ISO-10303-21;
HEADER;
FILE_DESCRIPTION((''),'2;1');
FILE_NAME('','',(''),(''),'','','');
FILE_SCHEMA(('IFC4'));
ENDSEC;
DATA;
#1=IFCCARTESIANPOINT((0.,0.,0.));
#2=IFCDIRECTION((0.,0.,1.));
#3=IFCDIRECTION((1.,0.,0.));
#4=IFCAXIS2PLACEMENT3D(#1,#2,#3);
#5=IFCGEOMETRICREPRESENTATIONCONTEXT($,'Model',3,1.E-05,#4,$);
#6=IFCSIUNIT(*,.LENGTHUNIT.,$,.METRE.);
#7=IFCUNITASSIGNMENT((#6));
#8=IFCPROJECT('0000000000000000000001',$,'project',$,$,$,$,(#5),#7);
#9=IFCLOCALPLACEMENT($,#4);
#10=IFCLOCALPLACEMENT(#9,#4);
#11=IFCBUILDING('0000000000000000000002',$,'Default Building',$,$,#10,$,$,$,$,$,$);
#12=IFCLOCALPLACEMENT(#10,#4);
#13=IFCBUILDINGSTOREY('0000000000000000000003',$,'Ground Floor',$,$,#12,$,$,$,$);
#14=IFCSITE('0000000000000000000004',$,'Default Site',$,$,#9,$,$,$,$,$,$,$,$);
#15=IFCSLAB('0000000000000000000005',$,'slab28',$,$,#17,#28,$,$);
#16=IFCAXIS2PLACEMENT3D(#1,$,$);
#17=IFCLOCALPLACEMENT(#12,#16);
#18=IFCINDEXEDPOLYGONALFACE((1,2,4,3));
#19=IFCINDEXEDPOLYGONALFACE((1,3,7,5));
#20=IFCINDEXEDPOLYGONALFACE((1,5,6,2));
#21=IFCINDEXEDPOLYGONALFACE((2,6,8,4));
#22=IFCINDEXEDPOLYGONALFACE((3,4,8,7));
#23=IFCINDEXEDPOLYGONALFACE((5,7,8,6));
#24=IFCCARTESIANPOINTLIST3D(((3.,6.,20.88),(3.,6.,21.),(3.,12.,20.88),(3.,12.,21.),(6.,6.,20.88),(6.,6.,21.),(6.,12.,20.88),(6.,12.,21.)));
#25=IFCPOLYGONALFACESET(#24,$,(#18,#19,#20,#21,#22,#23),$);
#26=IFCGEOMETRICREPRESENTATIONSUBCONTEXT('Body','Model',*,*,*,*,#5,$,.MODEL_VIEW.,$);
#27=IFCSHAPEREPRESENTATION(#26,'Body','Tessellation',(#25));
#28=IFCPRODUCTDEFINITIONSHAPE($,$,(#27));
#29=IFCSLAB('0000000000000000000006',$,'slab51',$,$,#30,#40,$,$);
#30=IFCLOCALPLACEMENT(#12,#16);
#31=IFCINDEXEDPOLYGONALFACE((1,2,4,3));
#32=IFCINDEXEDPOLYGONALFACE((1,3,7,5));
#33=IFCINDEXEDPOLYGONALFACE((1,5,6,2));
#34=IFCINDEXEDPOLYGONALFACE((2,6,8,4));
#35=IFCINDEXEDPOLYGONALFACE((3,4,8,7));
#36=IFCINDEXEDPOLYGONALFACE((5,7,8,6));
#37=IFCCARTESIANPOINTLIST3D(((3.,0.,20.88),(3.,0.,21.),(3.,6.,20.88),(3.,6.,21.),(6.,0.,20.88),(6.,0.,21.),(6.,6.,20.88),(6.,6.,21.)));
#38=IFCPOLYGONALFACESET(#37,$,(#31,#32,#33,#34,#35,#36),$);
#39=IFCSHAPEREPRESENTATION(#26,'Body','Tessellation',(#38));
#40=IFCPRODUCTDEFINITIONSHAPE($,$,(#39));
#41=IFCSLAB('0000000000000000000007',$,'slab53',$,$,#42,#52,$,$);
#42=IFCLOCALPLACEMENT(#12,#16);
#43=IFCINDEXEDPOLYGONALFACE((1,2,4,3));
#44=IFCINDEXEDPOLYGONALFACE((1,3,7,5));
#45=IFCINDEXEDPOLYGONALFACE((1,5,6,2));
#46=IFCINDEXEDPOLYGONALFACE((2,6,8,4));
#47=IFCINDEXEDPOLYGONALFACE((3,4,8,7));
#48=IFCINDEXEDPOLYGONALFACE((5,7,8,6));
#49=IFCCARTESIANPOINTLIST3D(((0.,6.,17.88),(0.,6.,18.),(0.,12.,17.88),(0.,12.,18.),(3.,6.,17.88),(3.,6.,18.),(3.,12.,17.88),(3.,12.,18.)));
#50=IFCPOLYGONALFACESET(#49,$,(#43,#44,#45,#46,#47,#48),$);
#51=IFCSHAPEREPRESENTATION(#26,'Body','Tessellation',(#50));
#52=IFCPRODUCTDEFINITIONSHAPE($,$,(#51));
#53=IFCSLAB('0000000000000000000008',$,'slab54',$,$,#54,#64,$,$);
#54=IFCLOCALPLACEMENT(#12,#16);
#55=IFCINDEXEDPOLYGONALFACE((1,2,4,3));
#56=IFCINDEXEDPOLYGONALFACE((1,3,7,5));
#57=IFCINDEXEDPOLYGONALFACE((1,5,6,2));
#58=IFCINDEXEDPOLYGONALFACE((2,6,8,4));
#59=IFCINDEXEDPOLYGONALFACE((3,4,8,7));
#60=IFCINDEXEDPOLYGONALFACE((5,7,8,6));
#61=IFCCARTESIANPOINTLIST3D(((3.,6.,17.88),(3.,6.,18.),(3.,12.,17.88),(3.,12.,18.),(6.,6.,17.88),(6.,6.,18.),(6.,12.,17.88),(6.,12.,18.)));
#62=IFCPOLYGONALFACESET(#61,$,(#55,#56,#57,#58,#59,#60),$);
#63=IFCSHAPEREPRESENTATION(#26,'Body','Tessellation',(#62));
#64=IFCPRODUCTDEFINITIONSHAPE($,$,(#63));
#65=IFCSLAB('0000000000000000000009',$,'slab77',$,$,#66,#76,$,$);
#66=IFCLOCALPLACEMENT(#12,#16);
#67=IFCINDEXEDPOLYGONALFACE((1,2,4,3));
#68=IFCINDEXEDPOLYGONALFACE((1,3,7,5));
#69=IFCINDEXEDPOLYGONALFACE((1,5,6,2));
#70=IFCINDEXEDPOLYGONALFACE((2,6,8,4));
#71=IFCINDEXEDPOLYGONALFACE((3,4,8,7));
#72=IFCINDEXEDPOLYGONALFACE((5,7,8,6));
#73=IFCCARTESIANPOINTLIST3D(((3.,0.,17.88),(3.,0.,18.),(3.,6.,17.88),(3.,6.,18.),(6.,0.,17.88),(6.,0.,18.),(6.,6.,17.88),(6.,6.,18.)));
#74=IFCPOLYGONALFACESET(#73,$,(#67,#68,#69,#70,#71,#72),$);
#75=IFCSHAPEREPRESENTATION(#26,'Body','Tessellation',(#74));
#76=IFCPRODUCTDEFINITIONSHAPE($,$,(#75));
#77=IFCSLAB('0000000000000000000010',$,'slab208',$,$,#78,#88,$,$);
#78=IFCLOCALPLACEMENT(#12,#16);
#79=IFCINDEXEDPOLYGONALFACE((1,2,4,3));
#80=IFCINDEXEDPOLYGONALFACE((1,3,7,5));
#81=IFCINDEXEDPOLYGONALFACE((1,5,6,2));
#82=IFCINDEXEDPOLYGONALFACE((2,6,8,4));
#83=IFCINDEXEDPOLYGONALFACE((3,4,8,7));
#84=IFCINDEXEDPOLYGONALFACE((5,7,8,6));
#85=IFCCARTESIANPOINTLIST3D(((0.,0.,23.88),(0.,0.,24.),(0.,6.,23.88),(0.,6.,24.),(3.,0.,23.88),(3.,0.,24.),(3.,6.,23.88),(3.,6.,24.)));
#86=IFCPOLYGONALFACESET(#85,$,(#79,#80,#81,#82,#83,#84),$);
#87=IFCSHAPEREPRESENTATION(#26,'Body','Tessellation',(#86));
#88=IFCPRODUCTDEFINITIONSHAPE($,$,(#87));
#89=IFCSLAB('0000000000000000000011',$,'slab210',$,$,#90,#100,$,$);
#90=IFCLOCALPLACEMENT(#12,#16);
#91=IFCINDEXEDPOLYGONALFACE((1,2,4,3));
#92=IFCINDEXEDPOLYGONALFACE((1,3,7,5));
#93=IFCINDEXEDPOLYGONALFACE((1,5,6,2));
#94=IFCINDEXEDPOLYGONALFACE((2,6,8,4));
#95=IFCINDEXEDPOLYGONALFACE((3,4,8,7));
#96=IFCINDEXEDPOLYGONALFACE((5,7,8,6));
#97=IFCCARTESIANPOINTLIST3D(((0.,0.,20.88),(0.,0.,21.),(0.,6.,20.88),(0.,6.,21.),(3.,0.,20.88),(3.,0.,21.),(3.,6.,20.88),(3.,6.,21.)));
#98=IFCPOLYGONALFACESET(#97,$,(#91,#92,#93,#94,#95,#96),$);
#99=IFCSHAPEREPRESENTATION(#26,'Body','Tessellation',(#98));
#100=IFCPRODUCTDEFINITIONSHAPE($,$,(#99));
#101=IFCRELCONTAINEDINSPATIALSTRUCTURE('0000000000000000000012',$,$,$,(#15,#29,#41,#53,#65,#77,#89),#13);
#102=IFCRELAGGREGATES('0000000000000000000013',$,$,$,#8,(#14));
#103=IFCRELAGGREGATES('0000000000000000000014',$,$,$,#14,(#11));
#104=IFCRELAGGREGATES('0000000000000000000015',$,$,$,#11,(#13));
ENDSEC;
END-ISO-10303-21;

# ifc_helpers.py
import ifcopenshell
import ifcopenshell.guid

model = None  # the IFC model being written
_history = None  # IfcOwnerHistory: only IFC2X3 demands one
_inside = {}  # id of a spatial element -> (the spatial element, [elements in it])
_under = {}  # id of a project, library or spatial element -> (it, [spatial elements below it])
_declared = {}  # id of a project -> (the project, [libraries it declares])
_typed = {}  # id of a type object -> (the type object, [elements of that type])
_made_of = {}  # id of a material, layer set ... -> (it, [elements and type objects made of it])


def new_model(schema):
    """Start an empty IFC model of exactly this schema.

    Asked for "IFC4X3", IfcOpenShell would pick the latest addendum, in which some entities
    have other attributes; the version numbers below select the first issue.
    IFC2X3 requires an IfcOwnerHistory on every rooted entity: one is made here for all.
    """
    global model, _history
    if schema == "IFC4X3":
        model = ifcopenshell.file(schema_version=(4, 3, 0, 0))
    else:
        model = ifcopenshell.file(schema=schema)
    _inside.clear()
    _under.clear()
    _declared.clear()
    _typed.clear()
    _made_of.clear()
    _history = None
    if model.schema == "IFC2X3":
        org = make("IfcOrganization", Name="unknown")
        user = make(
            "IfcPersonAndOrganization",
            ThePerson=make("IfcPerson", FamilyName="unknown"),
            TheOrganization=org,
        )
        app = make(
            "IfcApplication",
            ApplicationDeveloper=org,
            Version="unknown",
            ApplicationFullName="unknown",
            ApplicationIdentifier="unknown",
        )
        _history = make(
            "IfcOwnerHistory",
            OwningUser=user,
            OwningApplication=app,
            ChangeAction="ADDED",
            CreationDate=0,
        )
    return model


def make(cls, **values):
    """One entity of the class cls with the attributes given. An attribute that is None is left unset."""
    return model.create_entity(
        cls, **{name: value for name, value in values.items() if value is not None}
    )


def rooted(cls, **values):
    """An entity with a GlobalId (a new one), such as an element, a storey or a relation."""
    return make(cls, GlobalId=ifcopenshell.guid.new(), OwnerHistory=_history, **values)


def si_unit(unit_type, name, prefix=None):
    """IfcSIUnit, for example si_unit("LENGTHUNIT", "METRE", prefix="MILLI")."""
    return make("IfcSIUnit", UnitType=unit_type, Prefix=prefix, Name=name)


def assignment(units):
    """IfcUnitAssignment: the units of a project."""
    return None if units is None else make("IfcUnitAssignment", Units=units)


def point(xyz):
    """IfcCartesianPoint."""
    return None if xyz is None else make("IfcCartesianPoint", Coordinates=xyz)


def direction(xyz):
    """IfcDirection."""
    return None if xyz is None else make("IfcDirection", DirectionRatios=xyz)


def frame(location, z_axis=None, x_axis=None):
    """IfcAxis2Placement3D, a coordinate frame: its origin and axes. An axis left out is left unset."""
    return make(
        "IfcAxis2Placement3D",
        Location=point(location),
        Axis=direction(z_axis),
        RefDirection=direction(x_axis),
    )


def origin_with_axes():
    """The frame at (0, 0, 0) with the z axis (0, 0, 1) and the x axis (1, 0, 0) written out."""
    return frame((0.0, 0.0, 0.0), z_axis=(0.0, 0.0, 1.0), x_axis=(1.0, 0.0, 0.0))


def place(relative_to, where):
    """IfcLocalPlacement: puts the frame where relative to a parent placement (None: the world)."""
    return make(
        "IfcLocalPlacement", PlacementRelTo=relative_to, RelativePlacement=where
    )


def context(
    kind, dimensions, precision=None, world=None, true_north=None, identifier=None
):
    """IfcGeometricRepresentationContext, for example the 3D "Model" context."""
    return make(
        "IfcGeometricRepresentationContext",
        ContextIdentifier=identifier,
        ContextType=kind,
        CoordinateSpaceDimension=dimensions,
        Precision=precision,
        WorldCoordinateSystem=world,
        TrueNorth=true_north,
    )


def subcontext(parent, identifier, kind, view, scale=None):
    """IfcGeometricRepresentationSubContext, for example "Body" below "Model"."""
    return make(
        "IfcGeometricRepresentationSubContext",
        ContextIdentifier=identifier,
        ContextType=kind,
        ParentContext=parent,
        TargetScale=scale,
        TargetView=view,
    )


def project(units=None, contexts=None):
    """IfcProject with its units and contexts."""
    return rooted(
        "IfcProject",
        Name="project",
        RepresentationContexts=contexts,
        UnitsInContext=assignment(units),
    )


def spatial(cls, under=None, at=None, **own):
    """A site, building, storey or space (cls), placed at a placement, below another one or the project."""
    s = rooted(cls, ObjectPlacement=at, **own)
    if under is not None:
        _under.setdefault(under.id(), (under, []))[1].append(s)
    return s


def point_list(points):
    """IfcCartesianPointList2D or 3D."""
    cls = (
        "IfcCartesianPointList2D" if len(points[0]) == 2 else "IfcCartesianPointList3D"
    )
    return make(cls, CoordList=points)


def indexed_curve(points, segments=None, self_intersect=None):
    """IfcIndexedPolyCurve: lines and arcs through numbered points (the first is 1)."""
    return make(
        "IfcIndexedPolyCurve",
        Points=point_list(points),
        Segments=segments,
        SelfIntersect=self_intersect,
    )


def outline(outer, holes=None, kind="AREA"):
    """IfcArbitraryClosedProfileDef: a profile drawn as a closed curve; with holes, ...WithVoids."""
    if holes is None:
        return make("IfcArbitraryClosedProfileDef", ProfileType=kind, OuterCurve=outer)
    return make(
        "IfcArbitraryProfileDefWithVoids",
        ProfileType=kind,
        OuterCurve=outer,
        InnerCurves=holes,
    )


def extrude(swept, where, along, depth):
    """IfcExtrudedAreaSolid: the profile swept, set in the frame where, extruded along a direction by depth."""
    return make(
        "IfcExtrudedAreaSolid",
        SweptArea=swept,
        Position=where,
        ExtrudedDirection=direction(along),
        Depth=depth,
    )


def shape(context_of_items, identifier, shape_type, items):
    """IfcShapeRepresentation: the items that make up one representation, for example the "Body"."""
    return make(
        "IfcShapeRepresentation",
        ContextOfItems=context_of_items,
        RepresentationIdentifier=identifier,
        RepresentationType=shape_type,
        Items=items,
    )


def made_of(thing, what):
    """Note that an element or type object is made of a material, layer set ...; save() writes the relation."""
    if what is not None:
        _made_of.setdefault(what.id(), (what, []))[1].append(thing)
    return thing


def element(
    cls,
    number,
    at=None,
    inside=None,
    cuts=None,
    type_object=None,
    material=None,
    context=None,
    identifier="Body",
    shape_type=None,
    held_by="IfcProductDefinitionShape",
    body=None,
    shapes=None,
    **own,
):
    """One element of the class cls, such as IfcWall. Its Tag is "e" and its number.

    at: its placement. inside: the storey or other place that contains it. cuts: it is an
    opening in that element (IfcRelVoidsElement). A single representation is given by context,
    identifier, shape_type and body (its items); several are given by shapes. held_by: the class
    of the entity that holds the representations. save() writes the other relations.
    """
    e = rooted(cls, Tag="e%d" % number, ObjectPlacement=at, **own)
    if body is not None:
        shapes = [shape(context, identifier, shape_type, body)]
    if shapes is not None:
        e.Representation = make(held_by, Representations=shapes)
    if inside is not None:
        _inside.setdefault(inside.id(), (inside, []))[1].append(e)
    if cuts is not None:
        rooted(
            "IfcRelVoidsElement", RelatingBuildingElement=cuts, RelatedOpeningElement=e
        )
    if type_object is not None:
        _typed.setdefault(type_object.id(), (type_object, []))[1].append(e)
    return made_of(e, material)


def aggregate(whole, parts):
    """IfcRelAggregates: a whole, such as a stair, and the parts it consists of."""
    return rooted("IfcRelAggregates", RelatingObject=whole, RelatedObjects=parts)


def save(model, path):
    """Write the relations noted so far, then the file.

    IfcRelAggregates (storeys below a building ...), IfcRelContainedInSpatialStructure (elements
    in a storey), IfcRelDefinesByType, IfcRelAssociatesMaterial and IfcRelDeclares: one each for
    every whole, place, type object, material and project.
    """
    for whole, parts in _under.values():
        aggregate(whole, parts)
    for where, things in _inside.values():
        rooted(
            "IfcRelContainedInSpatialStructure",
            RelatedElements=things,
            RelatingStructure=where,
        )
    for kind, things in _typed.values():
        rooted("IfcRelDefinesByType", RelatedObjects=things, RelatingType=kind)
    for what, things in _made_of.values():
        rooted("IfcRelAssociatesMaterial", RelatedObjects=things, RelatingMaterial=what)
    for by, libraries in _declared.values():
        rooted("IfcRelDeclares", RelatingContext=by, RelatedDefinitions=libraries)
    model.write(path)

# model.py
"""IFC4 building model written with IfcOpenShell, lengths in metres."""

from ifc_helpers import new_model, si_unit, frame, origin_with_axes, place, context, subcontext, project, spatial, indexed_curve, outline, extrude, element, save


model = new_model("IFC4")

# Units and contexts
model_context = context("Model", 3, precision=1e-05, world=origin_with_axes())
body_context = subcontext(model_context, "Body", "Model", "MODEL_VIEW")
ifc_project = project(units=[si_unit("LENGTHUNIT", "METRE")], contexts=[model_context])

# Site, building, storey
site_placement = place(None, origin_with_axes())
site = spatial("IfcSite", under=ifc_project, at=site_placement, Name="Default Site")
building_placement = place(site_placement, origin_with_axes())
building = spatial("IfcBuilding", under=site, at=building_placement, Name="Default Building")
storey_placement = place(building_placement, origin_with_axes())
storey = spatial("IfcBuildingStorey", under=building, at=storey_placement, Name="Ground Floor")

# Slabs
for number, where, z_axis, x_axis, name in (
    (1, (3.0, 6.0, 20.88), (0.0, 0.0, 1.0), (1.0, 0.0, 0.0), "slab28"),
    (2, (3.0, 0.0, 20.88), (0.0, 0.0, 1.0), (1.0, 0.0, 0.0), "slab51"),
    (3, (0.0, 6.0, 17.88), (0.0, 0.0, 1.0), (1.0, 0.0, 0.0), "slab53"),
    (4, (3.0, 6.0, 17.88), (0.0, 0.0, 1.0), (1.0, 0.0, 0.0), "slab54"),
    (5, (3.0, 0.0, 17.88), (0.0, 0.0, 1.0), (1.0, 0.0, 0.0), "slab77"),
    (6, (0.0, 0.0, 23.88), (0.0, 0.0, 1.0), (1.0, 0.0, 0.0), "slab208"),
    (7, (0.0, 0.0, 20.88), (0.0, 0.0, 1.0), (1.0, 0.0, 0.0), "slab210"),
):
    element("IfcSlab", number, at=place(storey_placement, frame(where, z_axis=z_axis, x_axis=x_axis)), inside=storey, Name=name, context=body_context, shape_type="SweptSolid", body=[
        extrude(outline(indexed_curve([(0.0, 0.0), (0.0, 6.0), (3.0, 6.0), (3.0, 0.0), (0.0, 0.0)], self_intersect=False)), origin_with_axes(), (0.0, 0.0, 1.0), 0.12),
    ])

save(model, "model.ifc")
